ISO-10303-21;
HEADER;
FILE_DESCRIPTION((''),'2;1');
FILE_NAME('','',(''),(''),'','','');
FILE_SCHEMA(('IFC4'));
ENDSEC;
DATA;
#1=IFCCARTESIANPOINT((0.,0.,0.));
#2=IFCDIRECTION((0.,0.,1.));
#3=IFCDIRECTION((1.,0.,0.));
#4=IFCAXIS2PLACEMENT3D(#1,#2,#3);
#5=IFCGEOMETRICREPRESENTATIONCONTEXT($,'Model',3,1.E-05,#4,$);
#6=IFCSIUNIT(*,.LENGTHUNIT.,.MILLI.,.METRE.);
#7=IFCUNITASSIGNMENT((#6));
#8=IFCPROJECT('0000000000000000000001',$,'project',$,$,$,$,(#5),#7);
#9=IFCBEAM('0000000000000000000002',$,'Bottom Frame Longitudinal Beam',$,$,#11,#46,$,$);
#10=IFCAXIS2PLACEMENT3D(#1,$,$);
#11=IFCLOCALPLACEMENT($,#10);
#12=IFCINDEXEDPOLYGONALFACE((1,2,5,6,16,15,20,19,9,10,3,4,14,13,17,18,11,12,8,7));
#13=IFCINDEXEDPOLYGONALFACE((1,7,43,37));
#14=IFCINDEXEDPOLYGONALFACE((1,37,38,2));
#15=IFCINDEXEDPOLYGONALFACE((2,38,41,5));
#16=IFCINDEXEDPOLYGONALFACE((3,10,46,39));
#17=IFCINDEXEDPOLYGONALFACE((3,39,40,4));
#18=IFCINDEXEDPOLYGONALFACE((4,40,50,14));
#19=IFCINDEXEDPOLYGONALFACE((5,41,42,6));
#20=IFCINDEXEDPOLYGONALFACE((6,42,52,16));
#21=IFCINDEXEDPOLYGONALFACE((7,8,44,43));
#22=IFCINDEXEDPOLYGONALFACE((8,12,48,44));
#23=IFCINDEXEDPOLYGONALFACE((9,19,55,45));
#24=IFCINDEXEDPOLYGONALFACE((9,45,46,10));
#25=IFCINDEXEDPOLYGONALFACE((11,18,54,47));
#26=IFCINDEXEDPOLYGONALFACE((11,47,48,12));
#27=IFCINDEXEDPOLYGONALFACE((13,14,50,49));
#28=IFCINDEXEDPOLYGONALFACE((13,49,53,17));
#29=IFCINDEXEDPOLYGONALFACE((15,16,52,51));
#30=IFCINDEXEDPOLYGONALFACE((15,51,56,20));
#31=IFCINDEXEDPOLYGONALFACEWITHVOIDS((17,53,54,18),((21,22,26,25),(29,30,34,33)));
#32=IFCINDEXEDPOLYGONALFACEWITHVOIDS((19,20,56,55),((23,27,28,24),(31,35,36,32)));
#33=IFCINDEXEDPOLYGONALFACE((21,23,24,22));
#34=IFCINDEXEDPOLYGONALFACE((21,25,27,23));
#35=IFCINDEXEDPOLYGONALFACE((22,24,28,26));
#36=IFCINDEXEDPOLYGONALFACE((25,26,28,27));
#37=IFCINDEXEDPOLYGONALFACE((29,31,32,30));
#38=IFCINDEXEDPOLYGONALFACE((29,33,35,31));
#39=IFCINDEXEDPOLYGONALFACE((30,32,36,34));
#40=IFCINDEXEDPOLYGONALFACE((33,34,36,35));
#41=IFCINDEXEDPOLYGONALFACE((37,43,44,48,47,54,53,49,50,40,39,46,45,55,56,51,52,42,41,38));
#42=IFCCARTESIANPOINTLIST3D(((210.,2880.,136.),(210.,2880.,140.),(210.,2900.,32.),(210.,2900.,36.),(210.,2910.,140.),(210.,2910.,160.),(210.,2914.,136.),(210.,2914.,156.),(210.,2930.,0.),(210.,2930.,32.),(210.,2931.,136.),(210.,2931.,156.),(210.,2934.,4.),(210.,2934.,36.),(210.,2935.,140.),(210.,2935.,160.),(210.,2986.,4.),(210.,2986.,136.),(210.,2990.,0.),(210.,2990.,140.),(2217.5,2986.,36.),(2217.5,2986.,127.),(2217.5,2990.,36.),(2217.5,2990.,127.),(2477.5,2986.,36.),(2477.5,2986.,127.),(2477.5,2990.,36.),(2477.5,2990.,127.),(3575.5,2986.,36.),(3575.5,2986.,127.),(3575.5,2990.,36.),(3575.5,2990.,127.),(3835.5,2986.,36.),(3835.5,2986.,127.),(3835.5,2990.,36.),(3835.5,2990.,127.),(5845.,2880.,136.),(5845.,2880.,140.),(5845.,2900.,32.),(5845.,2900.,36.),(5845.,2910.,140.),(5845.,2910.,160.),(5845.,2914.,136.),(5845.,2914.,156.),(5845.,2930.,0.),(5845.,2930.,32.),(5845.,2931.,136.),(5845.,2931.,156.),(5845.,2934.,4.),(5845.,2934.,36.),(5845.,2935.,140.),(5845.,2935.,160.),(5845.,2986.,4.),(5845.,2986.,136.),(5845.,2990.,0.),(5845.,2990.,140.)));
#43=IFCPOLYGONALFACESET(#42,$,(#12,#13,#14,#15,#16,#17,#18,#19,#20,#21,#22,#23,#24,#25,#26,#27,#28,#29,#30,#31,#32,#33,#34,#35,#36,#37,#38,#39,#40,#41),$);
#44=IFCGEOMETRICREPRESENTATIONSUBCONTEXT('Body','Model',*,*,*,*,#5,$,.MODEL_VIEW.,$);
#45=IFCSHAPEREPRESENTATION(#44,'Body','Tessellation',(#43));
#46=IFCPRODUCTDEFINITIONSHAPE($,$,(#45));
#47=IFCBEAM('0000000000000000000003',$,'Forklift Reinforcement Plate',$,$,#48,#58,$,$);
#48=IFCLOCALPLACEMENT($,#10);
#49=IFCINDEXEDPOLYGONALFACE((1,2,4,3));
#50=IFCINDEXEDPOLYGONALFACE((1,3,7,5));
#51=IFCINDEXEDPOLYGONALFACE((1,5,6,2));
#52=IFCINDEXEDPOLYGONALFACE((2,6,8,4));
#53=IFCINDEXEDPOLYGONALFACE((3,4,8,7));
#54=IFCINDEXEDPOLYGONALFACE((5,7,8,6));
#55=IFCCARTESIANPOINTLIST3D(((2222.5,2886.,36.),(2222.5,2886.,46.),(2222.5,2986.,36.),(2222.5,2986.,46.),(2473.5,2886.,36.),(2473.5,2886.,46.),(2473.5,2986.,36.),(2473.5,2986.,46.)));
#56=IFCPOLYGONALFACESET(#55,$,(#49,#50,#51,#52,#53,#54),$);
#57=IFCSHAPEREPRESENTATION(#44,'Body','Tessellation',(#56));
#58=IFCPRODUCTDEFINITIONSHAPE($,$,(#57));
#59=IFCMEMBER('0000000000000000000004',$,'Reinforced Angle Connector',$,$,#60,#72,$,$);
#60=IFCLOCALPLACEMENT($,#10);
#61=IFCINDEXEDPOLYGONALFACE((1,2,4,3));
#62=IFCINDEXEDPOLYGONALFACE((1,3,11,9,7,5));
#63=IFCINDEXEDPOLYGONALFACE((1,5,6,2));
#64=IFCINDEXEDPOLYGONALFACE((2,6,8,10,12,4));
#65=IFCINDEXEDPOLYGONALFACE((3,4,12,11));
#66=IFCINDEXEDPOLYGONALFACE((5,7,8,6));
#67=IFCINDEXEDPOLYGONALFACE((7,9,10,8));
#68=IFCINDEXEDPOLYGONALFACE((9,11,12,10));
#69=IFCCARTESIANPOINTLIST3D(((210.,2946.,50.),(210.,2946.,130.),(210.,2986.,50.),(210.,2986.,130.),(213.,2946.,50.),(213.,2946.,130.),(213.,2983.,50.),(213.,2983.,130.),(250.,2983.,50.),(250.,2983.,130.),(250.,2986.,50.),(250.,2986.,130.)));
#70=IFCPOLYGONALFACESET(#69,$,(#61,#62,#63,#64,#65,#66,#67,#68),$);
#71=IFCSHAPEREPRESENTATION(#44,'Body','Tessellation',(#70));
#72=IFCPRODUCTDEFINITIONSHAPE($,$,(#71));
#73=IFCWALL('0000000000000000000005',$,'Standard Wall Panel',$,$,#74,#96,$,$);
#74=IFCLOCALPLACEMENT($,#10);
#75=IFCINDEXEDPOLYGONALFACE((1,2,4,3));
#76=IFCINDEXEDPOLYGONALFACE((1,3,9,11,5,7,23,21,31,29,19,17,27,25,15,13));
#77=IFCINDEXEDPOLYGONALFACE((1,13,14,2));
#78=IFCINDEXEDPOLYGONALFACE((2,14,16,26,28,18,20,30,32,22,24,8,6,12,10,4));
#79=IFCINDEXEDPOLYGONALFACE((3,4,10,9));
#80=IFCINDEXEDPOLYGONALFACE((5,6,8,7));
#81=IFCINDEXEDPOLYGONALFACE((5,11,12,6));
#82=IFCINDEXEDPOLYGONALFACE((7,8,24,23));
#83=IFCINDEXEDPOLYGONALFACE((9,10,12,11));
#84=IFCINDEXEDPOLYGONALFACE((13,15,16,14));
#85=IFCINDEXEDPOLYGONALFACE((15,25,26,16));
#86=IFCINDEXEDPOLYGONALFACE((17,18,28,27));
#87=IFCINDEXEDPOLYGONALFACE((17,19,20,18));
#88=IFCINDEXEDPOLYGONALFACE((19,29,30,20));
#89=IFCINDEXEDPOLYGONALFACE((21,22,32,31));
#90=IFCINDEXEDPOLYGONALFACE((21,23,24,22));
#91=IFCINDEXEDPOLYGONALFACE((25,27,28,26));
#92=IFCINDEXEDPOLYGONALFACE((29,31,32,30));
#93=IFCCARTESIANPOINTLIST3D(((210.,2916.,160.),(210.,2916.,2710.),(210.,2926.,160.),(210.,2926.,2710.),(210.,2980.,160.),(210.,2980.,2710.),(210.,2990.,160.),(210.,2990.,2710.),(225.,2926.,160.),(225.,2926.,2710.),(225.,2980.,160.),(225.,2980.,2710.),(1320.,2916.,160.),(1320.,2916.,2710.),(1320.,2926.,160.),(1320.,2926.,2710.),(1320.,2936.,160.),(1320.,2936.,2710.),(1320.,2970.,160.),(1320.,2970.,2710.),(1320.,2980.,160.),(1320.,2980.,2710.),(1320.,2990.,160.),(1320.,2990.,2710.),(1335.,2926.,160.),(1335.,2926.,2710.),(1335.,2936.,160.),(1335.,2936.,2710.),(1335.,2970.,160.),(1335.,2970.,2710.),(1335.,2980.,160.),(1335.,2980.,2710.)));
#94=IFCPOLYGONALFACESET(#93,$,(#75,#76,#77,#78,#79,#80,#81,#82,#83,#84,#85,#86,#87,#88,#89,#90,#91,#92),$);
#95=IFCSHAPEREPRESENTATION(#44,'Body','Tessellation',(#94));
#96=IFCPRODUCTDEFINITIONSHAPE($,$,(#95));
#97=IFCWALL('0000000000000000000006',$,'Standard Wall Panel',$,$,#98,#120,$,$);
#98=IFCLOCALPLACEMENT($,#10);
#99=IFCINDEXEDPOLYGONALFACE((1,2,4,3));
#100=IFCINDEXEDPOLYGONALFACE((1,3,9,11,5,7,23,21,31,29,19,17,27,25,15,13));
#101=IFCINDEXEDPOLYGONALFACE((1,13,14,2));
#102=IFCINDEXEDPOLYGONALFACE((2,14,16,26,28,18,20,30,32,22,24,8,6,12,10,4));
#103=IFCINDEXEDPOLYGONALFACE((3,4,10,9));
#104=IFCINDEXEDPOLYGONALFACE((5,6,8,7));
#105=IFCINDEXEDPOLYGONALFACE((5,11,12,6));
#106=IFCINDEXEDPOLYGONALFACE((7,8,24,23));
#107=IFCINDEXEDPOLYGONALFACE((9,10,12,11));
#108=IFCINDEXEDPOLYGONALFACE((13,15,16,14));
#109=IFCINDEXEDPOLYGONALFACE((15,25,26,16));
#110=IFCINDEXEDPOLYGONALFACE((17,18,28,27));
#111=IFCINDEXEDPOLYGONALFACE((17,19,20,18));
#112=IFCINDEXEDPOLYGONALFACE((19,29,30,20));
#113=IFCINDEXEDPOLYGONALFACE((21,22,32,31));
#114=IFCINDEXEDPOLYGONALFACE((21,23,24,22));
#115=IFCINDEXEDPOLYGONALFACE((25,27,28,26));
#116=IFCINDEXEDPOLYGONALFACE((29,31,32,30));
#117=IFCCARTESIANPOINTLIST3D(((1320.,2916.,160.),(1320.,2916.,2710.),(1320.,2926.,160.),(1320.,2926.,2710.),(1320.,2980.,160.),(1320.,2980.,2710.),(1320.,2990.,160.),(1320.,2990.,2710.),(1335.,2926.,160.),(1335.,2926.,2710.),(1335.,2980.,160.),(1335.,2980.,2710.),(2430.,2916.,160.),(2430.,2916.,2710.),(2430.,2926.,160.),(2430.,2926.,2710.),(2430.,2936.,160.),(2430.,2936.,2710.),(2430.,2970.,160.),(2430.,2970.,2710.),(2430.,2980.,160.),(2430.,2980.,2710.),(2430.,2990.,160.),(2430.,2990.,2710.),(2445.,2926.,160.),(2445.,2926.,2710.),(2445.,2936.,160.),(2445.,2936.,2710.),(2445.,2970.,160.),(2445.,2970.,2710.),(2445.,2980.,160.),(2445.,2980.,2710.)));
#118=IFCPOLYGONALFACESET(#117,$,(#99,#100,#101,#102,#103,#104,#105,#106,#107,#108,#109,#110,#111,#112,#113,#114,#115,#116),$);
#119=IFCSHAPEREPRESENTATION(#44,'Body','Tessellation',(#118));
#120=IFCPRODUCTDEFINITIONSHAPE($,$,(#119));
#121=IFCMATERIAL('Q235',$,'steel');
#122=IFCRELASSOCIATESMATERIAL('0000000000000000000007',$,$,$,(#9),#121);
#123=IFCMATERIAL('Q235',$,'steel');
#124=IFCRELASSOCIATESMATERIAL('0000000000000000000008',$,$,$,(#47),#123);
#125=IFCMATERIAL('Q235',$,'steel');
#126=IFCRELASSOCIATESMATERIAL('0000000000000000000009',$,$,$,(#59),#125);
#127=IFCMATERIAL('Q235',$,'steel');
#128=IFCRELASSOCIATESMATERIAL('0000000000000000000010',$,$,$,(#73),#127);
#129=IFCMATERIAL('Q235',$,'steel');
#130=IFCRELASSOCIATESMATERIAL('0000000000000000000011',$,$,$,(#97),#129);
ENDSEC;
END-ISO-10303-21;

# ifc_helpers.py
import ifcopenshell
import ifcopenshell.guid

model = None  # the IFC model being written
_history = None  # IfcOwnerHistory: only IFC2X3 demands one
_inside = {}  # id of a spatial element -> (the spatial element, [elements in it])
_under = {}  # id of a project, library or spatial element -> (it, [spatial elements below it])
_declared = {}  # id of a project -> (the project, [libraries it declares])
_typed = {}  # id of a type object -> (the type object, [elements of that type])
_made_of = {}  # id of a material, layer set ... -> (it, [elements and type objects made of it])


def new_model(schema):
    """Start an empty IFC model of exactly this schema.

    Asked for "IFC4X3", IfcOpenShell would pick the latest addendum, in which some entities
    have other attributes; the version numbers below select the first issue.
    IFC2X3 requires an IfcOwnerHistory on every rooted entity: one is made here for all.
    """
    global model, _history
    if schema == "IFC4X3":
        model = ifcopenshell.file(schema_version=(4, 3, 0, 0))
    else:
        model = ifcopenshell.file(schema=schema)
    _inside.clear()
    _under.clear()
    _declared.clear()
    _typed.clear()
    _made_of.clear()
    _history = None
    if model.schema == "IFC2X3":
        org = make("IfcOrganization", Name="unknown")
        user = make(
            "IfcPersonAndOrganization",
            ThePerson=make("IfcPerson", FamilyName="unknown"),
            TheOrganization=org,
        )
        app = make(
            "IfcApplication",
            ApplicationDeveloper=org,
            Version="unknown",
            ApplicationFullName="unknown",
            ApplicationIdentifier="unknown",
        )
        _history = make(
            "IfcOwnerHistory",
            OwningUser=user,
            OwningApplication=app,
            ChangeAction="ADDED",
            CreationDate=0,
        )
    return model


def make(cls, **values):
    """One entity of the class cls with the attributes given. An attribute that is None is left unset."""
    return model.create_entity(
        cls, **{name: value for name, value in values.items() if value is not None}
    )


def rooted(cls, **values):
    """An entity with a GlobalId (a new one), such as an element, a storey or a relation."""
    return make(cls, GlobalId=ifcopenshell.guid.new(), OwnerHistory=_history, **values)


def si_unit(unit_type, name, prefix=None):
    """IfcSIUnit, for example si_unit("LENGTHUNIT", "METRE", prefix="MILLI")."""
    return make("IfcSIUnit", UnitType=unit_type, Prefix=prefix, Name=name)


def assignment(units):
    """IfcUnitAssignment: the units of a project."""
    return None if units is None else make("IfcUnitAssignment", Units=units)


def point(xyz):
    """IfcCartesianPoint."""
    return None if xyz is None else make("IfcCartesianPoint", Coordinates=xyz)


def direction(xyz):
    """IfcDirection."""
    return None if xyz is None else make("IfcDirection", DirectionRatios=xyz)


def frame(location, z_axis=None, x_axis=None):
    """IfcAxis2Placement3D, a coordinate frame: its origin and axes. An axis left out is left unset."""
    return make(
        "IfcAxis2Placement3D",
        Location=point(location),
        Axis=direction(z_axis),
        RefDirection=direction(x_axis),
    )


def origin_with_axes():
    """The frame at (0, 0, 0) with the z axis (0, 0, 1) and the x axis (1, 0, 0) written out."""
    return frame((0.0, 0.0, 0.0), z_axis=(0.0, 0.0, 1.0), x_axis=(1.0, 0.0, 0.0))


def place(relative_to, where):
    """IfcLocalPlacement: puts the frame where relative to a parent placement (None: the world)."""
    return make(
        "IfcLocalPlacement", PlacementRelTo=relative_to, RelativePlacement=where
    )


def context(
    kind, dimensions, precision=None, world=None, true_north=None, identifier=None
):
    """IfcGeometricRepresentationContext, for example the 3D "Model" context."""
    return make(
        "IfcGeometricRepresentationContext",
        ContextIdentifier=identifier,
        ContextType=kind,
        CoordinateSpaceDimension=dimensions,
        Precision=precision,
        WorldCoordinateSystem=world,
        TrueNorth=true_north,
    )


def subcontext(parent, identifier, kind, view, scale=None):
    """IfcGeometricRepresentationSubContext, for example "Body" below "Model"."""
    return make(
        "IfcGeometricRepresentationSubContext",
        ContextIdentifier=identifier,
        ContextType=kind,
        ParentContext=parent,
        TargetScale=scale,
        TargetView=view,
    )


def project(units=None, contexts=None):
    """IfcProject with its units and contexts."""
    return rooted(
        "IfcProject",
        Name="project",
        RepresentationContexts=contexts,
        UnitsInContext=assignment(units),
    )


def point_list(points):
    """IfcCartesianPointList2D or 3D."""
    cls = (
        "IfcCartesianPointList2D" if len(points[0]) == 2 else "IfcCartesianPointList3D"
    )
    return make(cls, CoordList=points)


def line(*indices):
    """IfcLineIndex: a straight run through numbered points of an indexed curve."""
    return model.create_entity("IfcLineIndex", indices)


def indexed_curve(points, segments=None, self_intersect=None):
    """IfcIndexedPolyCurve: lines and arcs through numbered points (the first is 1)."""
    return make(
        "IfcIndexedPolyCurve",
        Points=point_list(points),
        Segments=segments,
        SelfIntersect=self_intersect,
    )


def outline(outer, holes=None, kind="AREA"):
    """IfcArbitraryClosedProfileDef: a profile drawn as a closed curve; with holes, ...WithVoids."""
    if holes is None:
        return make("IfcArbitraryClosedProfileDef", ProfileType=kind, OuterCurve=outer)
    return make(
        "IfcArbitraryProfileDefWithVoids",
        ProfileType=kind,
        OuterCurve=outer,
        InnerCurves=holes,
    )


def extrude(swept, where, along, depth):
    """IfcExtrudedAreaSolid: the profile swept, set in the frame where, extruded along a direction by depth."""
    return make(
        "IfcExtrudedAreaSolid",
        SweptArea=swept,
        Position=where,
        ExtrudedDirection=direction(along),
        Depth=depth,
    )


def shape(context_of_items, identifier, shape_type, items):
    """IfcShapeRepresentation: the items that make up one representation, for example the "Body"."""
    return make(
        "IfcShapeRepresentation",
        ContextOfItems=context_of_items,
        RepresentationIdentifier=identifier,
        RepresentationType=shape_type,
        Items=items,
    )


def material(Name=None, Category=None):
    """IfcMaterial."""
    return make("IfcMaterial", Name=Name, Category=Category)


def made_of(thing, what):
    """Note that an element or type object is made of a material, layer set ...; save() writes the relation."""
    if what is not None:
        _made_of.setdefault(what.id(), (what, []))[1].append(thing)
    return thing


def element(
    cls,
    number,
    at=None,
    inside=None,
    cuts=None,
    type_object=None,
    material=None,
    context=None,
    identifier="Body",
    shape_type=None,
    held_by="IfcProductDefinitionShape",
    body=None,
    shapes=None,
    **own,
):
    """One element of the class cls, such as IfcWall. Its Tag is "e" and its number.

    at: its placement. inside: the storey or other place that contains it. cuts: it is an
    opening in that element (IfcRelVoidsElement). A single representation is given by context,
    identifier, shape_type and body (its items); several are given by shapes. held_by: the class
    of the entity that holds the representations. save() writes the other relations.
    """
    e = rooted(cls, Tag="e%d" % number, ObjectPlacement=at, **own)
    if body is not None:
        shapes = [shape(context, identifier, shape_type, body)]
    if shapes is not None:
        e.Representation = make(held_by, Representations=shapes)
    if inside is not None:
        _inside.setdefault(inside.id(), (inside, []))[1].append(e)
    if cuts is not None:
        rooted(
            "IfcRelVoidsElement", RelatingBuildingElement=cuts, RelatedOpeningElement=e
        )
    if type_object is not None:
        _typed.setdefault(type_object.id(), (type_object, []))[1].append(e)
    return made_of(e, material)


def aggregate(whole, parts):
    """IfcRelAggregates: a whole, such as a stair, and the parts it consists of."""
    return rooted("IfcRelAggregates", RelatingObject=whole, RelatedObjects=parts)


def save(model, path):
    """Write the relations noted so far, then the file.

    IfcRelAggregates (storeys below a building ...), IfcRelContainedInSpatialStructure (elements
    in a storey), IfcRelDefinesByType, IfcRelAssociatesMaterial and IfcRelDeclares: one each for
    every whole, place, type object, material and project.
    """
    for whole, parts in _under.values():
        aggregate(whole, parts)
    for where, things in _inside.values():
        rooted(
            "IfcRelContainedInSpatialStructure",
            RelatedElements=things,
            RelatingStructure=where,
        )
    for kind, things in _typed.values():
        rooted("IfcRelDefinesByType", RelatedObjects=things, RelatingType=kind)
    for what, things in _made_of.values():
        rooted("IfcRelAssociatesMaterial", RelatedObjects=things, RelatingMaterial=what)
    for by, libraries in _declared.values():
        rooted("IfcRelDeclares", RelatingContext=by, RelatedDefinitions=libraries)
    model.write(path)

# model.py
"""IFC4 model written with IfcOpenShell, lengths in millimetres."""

from ifc_helpers import new_model, si_unit, frame, origin_with_axes, place, context, subcontext, project, line, indexed_curve, outline, extrude, material, element, save


model = new_model("IFC4")

# Units and contexts
model_context = context("Model", 3, precision=1e-05, world=origin_with_axes())
body_context = subcontext(model_context, "Body", "Model", "MODEL_VIEW")
ifc_project = project(units=[si_unit("LENGTHUNIT", "METRE", prefix="MILLI")], contexts=[model_context])

# Beam, openings
ifc_material_1 = material(Name="Q235", Category="steel")
beam_1_placement = place(None, frame((210.0, 2990.0, 0.0), z_axis=(1.0, 0.0, 0.0), x_axis=(0.0, -1.0, 0.0)))
beam_1 = element("IfcBeam", 1, at=beam_1_placement, material=ifc_material_1, Name="Bottom Frame Longitudinal Beam", context=body_context, shape_type="SweptSolid", body=[
    extrude(outline(indexed_curve([(0.0, 0.0), (60.0, 0.0), (60.0, -32.0), (90.0, -32.0), (90.0, -36.0), (56.0, -36.0), (56.0, -4.0), (4.0, -4.0), (4.0, -136.0), (59.0, -136.0), (59.0, -156.0), (76.0, -156.0), (76.0, -136.0), (110.0, -136.0), (110.0, -140.0), (80.0, -140.0), (80.0, -160.0), (55.0, -160.0), (55.0, -140.0), (0.0, -140.0), (0.0, 0.0)], segments=[line(1, 2, 3, 4, 5, 6, 7, 8, 9, 10, 11, 12, 13, 14, 15, 16, 17, 18, 19, 20, 21, 1)])), origin_with_axes(), (0.0, 0.0, 1.0), 5635.0),
])
opening_1_placement = place(beam_1_placement, frame((0.0, -36.0, 2267.5), z_axis=(1.0, 0.0, 0.0), x_axis=(0.0, 0.0, -1.0)))
element("IfcOpeningElement", 2, at=opening_1_placement, cuts=beam_1, context=body_context, shape_type="SweptSolid", body=[
    extrude(outline(indexed_curve([(0.0, 0.0), (0.0, -91.0), (260.0, -91.0), (260.0, 0.0), (0.0, 0.0)], segments=[line(1, 2, 3, 4, 5, 1)])), origin_with_axes(), (0.0, 0.0, 1.0), 4.0),
])
opening_2_placement = place(beam_1_placement, frame((0.0, -36.0, 3625.5), z_axis=(1.0, 0.0, 0.0), x_axis=(0.0, 0.0, -1.0)))
element("IfcOpeningElement", 3, at=opening_2_placement, cuts=beam_1, context=body_context, shape_type="SweptSolid", body=[
    extrude(outline(indexed_curve([(0.0, 0.0), (0.0, -91.0), (260.0, -91.0), (260.0, 0.0), (0.0, 0.0)], segments=[line(1, 2, 3, 4, 5, 1)])), origin_with_axes(), (0.0, 0.0, 1.0), 4.0),
])

# Beam
ifc_material_2 = material(Name="Q235", Category="steel")
beam_2_placement = place(None, frame((2222.5, 2886.0, 36.0), z_axis=(0.0, 0.0, 1.0), x_axis=(1.0, 0.0, 0.0)))
element("IfcBeam", 4, at=beam_2_placement, material=ifc_material_2, Name="Forklift Reinforcement Plate", context=body_context, shape_type="SweptSolid", body=[
    extrude(outline(indexed_curve([(0.0, 0.0), (0.0, 100.0), (251.0, 100.0), (251.0, 0.0), (0.0, 0.0)], segments=[line(1, 2, 3, 4, 5, 1)])), origin_with_axes(), (0.0, 0.0, 1.0), 10.0),
])

# Member
ifc_material_3 = material(Name="Q235", Category="steel")
member_1_placement = place(None, frame((210.0, 2986.0, 50.0), z_axis=(0.0, 0.0, 1.0), x_axis=(0.0, -1.0, 0.0)))
element("IfcMember", 5, at=member_1_placement, material=ifc_material_3, Name="Reinforced Angle Connector", context=body_context, shape_type="SweptSolid", body=[
    extrude(outline(indexed_curve([(0.0, 0.0), (0.0, 40.0), (3.0, 40.0), (3.0, 3.0), (40.0, 3.0), (40.0, 0.0), (0.0, 0.0)], segments=[line(1, 2, 3, 4, 5, 6, 7, 1)])), origin_with_axes(), (0.0, 0.0, 1.0), 80.0),
])

# Walls
ifc_material_4 = material(Name="Q235", Category="steel")
wall_1_placement = place(None, frame((210.0, 2916.0, 160.0), z_axis=(0.0, 0.0, 1.0), x_axis=(1.0, 0.0, 0.0)))
element("IfcWall", 6, at=wall_1_placement, material=ifc_material_4, Name="Standard Wall Panel", context=body_context, shape_type="SweptSolid", body=[
    extrude(outline(indexed_curve([(0.0, 0.0), (0.0, 10.0), (15.0, 10.0), (15.0, 64.0), (0.0, 64.0), (0.0, 74.0), (1110.0, 74.0), (1110.0, 64.0), (1125.0, 64.0), (1125.0, 54.0), (1125.0, 54.0), (1110.0, 54.0), (1110.0, 20.0), (1125.0, 20.0), (1125.0, 10.0), (1110.0, 10.0), (1110.0, 0.0), (0.0, 0.0)], segments=[line(1, 2, 3, 4, 5, 6, 7, 8, 9, 10, 11, 12, 13, 14, 15, 16, 17, 18, 1)])), origin_with_axes(), (0.0, 0.0, 1.0), 2550.0),
])
ifc_material_5 = material(Name="Q235", Category="steel")
wall_2_placement = place(None, frame((1320.0, 2916.0, 160.0), z_axis=(0.0, 0.0, 1.0), x_axis=(1.0, 0.0, 0.0)))
element("IfcWall", 7, at=wall_2_placement, material=ifc_material_5, Name="Standard Wall Panel", context=body_context, shape_type="SweptSolid", body=[
    extrude(outline(indexed_curve([(0.0, 0.0), (0.0, 10.0), (15.0, 10.0), (15.0, 64.0), (0.0, 64.0), (0.0, 74.0), (1110.0, 74.0), (1110.0, 64.0), (1125.0, 64.0), (1125.0, 54.0), (1125.0, 54.0), (1110.0, 54.0), (1110.0, 20.0), (1125.0, 20.0), (1125.0, 10.0), (1110.0, 10.0), (1110.0, 0.0), (0.0, 0.0)], segments=[line(1, 2, 3, 4, 5, 6, 7, 8, 9, 10, 11, 12, 13, 14, 15, 16, 17, 18, 1)])), origin_with_axes(), (0.0, 0.0, 1.0), 2550.0),
])

save(model, "model.ifc")
